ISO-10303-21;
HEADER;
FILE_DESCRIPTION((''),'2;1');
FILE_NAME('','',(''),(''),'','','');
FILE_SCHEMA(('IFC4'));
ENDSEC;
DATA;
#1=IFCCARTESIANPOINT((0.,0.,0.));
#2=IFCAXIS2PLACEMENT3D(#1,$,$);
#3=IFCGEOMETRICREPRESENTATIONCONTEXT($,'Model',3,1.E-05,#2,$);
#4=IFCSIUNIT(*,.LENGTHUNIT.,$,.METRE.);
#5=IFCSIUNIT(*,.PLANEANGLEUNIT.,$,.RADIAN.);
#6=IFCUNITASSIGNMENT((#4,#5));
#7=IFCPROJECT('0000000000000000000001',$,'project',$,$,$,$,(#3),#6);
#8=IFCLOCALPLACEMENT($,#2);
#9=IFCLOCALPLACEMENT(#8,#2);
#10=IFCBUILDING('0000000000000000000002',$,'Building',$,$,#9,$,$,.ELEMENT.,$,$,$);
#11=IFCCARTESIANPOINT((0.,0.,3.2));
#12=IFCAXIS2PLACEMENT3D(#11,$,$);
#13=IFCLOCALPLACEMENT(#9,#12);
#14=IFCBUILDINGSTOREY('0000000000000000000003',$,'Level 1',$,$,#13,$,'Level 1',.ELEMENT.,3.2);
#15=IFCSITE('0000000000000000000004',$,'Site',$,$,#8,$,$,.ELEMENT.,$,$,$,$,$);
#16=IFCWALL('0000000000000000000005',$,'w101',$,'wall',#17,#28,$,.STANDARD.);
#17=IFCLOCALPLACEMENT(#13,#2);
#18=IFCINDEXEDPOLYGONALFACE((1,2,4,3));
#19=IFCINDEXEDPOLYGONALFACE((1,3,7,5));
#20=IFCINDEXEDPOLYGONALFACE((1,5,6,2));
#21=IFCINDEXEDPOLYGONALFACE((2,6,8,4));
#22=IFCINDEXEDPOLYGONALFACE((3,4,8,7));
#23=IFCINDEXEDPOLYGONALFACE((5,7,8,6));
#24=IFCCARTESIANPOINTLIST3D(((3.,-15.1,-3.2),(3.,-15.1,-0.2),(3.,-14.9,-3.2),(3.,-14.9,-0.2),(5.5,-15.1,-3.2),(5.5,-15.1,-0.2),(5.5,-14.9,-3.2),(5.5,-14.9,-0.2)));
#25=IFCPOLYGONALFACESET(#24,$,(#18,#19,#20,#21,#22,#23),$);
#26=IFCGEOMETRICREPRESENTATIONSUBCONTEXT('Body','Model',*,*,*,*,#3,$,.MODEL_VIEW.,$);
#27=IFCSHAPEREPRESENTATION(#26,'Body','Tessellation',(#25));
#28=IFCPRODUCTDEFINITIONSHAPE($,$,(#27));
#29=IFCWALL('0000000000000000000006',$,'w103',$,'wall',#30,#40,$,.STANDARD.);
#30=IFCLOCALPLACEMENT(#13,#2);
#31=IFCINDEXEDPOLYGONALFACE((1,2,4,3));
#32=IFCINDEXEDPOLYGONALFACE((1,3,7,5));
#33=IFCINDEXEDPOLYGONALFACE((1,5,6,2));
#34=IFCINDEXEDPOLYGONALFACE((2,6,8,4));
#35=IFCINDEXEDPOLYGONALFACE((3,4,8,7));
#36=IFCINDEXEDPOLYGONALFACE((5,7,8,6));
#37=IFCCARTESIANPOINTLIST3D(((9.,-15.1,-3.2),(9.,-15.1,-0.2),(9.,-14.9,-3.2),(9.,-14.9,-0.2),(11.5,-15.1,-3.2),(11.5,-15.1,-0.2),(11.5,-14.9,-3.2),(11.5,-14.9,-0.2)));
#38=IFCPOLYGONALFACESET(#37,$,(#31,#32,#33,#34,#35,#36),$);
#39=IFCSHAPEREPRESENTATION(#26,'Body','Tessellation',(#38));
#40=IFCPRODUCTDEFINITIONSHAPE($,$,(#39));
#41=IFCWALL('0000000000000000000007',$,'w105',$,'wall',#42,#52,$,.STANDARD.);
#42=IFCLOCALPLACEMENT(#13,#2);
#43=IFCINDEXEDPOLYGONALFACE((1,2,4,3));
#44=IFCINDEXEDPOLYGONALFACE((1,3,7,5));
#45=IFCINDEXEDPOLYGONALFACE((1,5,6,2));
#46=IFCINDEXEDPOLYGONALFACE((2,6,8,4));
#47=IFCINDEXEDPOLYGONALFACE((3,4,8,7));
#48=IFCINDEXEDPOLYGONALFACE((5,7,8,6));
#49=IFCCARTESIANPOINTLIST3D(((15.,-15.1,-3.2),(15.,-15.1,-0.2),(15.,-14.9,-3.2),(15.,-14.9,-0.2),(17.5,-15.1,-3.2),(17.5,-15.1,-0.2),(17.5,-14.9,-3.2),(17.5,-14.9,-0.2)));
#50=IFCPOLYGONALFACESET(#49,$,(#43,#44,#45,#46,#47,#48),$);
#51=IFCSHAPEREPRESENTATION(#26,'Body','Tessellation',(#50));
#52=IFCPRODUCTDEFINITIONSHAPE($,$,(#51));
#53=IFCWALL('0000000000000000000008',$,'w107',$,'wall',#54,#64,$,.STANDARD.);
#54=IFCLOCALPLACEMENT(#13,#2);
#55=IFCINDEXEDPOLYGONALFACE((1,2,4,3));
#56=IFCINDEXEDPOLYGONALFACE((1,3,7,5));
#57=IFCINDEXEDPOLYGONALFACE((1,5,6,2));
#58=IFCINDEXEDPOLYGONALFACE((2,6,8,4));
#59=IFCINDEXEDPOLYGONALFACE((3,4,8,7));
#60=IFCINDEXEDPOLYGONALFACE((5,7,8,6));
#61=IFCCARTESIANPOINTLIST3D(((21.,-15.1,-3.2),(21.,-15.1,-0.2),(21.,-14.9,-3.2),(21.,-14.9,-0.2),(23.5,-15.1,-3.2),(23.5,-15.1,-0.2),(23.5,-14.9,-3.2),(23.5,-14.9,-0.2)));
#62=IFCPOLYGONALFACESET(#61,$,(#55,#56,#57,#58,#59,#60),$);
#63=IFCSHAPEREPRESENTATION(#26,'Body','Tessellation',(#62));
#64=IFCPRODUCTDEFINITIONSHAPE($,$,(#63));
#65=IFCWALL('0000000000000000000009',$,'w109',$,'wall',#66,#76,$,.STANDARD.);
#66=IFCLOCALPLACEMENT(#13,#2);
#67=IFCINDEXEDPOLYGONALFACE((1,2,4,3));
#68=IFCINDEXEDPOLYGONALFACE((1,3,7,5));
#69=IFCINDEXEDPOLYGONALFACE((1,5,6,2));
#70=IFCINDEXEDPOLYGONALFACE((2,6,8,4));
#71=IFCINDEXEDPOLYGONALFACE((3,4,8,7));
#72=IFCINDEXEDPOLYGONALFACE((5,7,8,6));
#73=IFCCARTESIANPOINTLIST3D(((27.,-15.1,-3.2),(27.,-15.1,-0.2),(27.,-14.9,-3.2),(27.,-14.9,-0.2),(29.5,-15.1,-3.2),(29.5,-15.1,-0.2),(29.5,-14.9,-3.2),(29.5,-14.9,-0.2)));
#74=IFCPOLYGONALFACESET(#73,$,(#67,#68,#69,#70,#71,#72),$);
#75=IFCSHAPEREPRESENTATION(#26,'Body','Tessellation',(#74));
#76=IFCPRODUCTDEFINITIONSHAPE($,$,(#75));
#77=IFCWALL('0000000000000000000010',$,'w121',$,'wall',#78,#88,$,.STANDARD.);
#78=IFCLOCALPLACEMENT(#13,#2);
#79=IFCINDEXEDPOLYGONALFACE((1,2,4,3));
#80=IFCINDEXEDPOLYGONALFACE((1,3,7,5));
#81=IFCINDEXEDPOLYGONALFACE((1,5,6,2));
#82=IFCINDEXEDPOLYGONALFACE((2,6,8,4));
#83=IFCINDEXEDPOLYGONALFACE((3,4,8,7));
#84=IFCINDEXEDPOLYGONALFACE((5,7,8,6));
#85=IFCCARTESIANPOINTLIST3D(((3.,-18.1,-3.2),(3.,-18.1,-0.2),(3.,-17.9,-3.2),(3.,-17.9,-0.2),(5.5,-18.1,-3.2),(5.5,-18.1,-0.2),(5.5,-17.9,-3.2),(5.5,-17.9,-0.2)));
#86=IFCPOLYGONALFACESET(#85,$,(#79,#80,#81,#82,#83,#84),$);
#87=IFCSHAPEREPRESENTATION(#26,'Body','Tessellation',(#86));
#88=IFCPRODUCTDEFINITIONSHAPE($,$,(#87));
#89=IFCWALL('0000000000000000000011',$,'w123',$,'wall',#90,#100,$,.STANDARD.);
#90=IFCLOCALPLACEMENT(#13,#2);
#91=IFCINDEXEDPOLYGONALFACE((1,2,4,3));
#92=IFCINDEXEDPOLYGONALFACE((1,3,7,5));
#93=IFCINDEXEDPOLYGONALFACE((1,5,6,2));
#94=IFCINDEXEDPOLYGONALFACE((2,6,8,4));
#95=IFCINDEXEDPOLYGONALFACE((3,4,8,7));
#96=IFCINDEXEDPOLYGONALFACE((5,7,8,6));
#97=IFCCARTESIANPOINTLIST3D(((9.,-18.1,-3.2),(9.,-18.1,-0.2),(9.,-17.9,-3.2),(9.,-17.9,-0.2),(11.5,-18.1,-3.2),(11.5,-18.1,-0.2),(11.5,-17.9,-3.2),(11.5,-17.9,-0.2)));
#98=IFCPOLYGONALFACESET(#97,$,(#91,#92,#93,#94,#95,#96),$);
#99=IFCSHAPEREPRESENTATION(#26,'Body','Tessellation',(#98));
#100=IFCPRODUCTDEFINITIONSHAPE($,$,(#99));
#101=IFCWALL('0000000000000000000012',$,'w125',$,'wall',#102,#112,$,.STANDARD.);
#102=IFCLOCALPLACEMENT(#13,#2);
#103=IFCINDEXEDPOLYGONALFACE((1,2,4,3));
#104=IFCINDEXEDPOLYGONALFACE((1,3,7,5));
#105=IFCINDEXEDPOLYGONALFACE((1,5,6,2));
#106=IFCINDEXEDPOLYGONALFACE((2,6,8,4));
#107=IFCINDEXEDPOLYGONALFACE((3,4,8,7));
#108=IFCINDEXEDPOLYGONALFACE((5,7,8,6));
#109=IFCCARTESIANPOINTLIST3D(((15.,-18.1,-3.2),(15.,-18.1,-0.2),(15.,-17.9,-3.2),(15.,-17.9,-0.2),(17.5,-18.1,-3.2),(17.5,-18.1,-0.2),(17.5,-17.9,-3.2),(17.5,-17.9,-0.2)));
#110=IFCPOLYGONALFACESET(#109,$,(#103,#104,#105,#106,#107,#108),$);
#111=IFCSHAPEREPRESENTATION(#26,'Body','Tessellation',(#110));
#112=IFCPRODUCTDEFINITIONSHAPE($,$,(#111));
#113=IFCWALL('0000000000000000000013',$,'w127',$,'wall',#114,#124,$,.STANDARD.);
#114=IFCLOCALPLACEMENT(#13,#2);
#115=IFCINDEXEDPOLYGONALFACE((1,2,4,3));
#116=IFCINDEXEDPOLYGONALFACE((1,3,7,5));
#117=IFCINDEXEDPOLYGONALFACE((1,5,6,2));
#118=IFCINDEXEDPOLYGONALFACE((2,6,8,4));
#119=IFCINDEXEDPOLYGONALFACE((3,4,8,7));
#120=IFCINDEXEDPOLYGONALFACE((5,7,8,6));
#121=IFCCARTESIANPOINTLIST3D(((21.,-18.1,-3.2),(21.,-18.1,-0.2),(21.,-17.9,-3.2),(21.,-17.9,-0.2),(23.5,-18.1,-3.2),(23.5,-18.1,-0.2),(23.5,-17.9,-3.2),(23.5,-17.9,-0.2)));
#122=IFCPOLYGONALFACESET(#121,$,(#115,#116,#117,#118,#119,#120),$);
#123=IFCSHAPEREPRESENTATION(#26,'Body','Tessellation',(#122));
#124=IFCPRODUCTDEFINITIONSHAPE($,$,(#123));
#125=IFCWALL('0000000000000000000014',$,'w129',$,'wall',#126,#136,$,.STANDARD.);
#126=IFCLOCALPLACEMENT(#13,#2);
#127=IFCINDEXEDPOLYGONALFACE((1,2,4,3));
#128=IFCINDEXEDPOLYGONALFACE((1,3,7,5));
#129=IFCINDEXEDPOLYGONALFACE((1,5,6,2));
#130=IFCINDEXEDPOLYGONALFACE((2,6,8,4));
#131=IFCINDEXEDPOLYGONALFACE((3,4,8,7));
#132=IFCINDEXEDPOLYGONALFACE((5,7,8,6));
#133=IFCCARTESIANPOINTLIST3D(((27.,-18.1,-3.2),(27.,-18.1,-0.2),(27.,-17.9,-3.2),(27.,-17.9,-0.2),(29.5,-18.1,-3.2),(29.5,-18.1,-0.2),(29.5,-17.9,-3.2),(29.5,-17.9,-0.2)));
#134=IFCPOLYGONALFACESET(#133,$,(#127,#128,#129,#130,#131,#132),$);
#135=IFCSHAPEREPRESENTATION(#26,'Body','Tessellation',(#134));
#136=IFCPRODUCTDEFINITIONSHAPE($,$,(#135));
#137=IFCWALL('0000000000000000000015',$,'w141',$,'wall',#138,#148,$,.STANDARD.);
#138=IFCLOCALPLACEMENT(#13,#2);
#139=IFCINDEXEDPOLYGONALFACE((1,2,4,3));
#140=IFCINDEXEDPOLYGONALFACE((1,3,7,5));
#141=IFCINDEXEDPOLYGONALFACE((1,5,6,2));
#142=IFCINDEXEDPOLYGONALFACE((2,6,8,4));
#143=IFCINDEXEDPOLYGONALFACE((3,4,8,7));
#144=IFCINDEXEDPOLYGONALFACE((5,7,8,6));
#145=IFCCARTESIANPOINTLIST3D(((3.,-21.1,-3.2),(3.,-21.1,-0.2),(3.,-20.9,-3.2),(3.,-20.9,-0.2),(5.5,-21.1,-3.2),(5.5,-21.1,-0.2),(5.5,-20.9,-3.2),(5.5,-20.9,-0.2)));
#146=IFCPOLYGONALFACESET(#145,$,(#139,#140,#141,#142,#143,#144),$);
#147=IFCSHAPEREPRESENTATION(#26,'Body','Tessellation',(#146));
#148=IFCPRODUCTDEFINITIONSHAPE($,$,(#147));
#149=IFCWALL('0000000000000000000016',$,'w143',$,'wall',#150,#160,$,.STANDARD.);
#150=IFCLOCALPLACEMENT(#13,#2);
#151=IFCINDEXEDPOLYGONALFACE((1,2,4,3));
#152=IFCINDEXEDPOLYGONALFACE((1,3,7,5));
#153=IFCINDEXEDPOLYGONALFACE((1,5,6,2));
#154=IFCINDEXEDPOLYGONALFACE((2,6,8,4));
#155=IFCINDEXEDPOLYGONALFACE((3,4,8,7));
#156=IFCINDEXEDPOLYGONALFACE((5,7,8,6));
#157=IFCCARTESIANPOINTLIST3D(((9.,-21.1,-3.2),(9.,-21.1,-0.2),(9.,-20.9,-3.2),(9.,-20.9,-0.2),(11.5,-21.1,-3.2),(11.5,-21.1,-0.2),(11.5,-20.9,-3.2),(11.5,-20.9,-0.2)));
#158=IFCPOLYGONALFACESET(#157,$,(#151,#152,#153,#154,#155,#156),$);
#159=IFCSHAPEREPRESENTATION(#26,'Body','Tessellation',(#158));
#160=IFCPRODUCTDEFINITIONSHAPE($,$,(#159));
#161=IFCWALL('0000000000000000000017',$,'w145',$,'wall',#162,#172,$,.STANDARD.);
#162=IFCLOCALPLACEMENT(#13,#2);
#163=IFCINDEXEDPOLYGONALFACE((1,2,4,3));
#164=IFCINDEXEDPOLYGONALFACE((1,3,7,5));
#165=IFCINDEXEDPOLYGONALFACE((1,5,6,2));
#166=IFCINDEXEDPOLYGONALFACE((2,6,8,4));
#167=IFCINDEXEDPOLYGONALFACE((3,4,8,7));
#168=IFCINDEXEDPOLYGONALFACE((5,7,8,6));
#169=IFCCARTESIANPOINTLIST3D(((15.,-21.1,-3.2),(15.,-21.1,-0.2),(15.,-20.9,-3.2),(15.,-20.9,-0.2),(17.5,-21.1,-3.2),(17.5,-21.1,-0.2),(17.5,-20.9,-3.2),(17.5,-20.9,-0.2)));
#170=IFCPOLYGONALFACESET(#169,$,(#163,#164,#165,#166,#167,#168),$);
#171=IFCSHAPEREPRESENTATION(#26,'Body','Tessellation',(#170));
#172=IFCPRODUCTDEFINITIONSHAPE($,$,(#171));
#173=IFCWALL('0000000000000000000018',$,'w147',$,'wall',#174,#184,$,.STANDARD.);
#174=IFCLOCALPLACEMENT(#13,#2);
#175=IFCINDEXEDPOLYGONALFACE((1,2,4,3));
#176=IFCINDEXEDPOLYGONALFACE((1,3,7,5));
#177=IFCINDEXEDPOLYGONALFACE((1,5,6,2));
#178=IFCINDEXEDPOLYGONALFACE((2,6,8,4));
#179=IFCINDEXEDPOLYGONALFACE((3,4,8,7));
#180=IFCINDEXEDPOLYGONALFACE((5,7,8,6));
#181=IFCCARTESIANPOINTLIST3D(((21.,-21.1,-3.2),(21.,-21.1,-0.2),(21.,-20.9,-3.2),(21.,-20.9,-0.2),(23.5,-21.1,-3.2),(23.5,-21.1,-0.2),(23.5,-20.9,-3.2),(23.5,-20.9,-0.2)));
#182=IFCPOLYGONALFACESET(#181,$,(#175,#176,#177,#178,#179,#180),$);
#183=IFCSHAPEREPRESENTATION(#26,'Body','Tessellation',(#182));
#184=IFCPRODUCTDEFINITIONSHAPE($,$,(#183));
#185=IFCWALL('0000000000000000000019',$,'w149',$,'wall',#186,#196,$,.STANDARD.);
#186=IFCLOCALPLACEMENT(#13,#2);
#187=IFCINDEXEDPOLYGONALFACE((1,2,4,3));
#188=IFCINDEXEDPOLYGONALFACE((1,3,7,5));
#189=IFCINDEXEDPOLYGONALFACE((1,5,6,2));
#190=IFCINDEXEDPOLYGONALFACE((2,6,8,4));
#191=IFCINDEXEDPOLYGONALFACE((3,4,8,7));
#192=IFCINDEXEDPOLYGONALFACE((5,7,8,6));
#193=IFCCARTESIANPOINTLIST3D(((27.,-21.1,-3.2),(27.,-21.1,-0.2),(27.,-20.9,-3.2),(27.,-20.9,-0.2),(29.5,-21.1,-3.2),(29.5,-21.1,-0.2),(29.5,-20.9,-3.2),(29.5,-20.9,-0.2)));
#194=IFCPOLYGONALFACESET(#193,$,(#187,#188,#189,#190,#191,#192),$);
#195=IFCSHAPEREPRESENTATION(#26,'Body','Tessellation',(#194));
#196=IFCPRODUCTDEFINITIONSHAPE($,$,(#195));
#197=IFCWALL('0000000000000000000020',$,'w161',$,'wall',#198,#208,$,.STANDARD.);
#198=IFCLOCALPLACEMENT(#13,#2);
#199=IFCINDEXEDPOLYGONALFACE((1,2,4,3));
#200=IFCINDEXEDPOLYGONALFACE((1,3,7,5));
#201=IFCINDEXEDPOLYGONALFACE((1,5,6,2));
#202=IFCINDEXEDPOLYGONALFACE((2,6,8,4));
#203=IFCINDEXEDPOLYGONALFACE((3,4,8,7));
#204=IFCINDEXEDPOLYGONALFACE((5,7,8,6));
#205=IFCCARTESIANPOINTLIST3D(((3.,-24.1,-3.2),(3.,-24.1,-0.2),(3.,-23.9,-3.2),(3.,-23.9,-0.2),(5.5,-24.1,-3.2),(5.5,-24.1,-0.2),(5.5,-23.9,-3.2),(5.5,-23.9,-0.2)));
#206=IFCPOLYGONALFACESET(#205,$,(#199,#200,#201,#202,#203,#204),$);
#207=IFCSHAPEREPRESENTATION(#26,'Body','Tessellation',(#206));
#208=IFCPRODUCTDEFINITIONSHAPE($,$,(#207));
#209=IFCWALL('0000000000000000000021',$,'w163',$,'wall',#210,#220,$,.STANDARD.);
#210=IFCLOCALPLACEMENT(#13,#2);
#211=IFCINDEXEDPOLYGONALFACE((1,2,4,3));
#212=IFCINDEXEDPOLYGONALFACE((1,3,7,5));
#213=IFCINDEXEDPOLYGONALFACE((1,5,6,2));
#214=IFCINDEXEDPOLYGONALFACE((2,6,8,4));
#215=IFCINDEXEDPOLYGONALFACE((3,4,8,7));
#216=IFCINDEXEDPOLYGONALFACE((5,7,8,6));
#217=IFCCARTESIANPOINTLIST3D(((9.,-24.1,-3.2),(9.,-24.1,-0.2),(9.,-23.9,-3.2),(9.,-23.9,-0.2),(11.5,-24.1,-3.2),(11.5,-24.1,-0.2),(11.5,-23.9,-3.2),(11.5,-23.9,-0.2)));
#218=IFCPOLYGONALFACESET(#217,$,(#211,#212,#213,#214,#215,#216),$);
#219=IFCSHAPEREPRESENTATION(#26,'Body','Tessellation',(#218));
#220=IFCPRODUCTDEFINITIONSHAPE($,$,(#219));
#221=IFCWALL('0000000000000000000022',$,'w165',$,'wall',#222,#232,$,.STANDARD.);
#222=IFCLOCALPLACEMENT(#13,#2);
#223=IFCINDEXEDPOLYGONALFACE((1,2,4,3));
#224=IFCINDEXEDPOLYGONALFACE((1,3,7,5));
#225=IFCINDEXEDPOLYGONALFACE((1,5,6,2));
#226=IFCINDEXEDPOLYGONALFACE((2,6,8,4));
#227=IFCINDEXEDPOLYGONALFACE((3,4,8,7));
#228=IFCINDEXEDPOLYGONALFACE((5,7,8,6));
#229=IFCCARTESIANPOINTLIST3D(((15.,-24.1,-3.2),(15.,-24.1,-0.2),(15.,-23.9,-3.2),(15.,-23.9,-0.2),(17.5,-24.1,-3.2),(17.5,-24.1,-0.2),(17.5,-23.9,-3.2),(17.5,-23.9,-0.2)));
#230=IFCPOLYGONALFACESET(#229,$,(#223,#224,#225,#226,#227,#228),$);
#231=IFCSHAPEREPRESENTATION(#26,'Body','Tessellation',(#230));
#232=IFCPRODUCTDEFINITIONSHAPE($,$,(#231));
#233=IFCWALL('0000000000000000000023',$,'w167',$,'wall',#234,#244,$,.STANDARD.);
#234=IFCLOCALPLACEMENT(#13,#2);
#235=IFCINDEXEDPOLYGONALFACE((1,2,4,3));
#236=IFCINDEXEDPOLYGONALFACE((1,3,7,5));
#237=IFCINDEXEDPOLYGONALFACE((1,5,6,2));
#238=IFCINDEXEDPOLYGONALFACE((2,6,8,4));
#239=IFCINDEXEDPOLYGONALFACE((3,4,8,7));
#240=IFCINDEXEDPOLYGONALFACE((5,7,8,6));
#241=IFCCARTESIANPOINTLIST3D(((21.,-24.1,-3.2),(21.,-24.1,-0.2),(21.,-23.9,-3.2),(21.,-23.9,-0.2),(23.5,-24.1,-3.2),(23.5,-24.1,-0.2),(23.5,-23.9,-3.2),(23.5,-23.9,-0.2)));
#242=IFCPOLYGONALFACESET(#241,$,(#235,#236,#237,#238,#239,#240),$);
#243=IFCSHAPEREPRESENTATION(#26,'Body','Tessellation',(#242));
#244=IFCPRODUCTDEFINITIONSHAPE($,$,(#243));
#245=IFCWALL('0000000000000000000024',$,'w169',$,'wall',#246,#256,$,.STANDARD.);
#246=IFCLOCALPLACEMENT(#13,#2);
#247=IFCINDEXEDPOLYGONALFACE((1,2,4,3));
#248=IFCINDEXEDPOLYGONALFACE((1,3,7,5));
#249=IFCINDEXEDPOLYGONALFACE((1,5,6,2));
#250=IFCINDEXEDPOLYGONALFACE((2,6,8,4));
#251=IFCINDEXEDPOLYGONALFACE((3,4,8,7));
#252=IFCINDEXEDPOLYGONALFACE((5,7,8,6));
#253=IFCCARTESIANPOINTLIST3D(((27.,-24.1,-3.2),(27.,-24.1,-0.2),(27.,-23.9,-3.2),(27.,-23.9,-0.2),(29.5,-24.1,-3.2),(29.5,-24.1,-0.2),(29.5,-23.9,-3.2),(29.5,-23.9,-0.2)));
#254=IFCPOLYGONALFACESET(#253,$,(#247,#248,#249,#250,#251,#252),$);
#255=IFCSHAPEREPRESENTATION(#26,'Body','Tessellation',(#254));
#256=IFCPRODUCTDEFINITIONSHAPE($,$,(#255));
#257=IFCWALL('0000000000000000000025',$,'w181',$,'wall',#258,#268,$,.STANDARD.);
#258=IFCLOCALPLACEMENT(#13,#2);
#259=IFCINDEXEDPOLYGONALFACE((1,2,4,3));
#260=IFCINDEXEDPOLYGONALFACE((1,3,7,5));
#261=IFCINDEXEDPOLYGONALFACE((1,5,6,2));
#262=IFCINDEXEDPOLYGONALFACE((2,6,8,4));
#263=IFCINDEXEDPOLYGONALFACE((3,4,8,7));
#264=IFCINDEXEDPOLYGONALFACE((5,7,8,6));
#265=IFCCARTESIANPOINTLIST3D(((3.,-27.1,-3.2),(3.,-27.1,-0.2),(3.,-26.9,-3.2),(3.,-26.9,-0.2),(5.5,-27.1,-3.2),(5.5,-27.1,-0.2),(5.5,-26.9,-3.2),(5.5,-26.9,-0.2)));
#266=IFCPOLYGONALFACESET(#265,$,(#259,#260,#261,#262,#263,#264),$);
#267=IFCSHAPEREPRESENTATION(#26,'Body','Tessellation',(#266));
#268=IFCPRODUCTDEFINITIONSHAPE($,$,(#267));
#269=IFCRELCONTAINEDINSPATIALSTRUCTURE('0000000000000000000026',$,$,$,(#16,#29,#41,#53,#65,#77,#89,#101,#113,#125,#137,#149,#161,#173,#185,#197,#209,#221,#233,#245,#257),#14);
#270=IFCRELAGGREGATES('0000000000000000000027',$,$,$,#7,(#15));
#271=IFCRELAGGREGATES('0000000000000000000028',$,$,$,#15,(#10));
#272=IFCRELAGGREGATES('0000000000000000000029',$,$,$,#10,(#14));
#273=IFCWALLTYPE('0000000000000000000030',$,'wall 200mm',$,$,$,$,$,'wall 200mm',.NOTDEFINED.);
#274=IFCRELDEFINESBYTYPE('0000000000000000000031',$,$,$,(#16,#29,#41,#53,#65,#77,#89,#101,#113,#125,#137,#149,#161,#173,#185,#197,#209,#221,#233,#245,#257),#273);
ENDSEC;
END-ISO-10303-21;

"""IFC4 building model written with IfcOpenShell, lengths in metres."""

from ifc_helpers import new_model, si_unit, frame, frame_2d, origin, place, context, subcontext, project, spatial, rectangle, extrude, type_object, element, save


model = new_model("IFC4")

# Units and contexts
model_context = context("Model", 3, precision=1e-05, world=origin())
body_context = subcontext(model_context, "Body", "Model", "MODEL_VIEW")
ifc_project = project(units=[si_unit("LENGTHUNIT", "METRE"), si_unit("PLANEANGLEUNIT", "RADIAN")], contexts=[model_context])

# Site, building, storey
site_placement = place(None, origin())
site = spatial("IfcSite", under=ifc_project, at=site_placement, Name="Site", CompositionType="ELEMENT")
building_placement = place(site_placement, origin())
building = spatial("IfcBuilding", under=site, at=building_placement, Name="Building", CompositionType="ELEMENT")
storey_placement = place(building_placement, frame((0.0, 0.0, 3.2)))
storey = spatial("IfcBuildingStorey", under=building, at=storey_placement, Name="Level 1", LongName="Level 1", CompositionType="ELEMENT", Elevation=3.2)

# Walls
wall_type = type_object("IfcWallType", Name="wall 200mm", ElementType="wall 200mm", PredefinedType="NOTDEFINED")
for number, where, z_axis, x_axis, name in (
    (1, (3.0, -15.0, -3.2), (0.0, 0.0, 1.0), (1.0, 0.0, 0.0), "w101"),
    (2, (9.0, -15.0, -3.2), (0.0, 0.0, 1.0), (1.0, 0.0, 0.0), "w103"),
    (3, (15.0, -15.0, -3.2), (0.0, 0.0, 1.0), (1.0, 0.0, 0.0), "w105"),
    (4, (21.0, -15.0, -3.2), (0.0, 0.0, 1.0), (1.0, 0.0, 0.0), "w107"),
    (5, (27.0, -15.0, -3.2), (0.0, 0.0, 1.0), (1.0, 0.0, 0.0), "w109"),
    (6, (3.0, -18.0, -3.2), (0.0, 0.0, 1.0), (1.0, 0.0, 0.0), "w121"),
    (7, (9.0, -18.0, -3.2), (0.0, 0.0, 1.0), (1.0, 0.0, 0.0), "w123"),
    (8, (15.0, -18.0, -3.2), (0.0, 0.0, 1.0), (1.0, 0.0, 0.0), "w125"),
    (9, (21.0, -18.0, -3.2), (0.0, 0.0, 1.0), (1.0, 0.0, 0.0), "w127"),
    (10, (27.0, -18.0, -3.2), (0.0, 0.0, 1.0), (1.0, 0.0, 0.0), "w129"),
    (11, (3.0, -21.0, -3.2), (0.0, 0.0, 1.0), (1.0, 0.0, 0.0), "w141"),
    (12, (9.0, -21.0, -3.2), (0.0, 0.0, 1.0), (1.0, 0.0, 0.0), "w143"),
    (13, (15.0, -21.0, -3.2), (0.0, 0.0, 1.0), (1.0, 0.0, 0.0), "w145"),
    (14, (21.0, -21.0, -3.2), (0.0, 0.0, 1.0), (1.0, 0.0, 0.0), "w147"),
    (15, (27.0, -21.0, -3.2), (0.0, 0.0, 1.0), (1.0, 0.0, 0.0), "w149"),
    (16, (3.0, -24.0, -3.2), (0.0, 0.0, 1.0), (1.0, 0.0, 0.0), "w161"),
    (17, (9.0, -24.0, -3.2), (0.0, 0.0, 1.0), (1.0, 0.0, 0.0), "w163"),
    (18, (15.0, -24.0, -3.2), (0.0, 0.0, 1.0), (1.0, 0.0, 0.0), "w165"),
    (19, (21.0, -24.0, -3.2), (0.0, 0.0, 1.0), (1.0, 0.0, 0.0), "w167"),
    (20, (27.0, -24.0, -3.2), (0.0, 0.0, 1.0), (1.0, 0.0, 0.0), "w169"),
    (21, (3.0, -27.0, -3.2), (0.0, 0.0, 1.0), (1.0, 0.0, 0.0), "w181"),
):
    element("IfcWall", number, at=place(storey_placement, frame(where, z_axis=z_axis, x_axis=x_axis)), inside=storey, type_object=wall_type, Name=name, ObjectType="wall", PredefinedType="STANDARD", context=body_context, shape_type="SweptSolid", body=[
        extrude(rectangle(XDim=2.5, YDim=0.2, at=frame_2d((1.25, 0.0))), origin(), (0.0, 0.0, 1.0), 3.0),
    ])

save(model, "model.ifc")
